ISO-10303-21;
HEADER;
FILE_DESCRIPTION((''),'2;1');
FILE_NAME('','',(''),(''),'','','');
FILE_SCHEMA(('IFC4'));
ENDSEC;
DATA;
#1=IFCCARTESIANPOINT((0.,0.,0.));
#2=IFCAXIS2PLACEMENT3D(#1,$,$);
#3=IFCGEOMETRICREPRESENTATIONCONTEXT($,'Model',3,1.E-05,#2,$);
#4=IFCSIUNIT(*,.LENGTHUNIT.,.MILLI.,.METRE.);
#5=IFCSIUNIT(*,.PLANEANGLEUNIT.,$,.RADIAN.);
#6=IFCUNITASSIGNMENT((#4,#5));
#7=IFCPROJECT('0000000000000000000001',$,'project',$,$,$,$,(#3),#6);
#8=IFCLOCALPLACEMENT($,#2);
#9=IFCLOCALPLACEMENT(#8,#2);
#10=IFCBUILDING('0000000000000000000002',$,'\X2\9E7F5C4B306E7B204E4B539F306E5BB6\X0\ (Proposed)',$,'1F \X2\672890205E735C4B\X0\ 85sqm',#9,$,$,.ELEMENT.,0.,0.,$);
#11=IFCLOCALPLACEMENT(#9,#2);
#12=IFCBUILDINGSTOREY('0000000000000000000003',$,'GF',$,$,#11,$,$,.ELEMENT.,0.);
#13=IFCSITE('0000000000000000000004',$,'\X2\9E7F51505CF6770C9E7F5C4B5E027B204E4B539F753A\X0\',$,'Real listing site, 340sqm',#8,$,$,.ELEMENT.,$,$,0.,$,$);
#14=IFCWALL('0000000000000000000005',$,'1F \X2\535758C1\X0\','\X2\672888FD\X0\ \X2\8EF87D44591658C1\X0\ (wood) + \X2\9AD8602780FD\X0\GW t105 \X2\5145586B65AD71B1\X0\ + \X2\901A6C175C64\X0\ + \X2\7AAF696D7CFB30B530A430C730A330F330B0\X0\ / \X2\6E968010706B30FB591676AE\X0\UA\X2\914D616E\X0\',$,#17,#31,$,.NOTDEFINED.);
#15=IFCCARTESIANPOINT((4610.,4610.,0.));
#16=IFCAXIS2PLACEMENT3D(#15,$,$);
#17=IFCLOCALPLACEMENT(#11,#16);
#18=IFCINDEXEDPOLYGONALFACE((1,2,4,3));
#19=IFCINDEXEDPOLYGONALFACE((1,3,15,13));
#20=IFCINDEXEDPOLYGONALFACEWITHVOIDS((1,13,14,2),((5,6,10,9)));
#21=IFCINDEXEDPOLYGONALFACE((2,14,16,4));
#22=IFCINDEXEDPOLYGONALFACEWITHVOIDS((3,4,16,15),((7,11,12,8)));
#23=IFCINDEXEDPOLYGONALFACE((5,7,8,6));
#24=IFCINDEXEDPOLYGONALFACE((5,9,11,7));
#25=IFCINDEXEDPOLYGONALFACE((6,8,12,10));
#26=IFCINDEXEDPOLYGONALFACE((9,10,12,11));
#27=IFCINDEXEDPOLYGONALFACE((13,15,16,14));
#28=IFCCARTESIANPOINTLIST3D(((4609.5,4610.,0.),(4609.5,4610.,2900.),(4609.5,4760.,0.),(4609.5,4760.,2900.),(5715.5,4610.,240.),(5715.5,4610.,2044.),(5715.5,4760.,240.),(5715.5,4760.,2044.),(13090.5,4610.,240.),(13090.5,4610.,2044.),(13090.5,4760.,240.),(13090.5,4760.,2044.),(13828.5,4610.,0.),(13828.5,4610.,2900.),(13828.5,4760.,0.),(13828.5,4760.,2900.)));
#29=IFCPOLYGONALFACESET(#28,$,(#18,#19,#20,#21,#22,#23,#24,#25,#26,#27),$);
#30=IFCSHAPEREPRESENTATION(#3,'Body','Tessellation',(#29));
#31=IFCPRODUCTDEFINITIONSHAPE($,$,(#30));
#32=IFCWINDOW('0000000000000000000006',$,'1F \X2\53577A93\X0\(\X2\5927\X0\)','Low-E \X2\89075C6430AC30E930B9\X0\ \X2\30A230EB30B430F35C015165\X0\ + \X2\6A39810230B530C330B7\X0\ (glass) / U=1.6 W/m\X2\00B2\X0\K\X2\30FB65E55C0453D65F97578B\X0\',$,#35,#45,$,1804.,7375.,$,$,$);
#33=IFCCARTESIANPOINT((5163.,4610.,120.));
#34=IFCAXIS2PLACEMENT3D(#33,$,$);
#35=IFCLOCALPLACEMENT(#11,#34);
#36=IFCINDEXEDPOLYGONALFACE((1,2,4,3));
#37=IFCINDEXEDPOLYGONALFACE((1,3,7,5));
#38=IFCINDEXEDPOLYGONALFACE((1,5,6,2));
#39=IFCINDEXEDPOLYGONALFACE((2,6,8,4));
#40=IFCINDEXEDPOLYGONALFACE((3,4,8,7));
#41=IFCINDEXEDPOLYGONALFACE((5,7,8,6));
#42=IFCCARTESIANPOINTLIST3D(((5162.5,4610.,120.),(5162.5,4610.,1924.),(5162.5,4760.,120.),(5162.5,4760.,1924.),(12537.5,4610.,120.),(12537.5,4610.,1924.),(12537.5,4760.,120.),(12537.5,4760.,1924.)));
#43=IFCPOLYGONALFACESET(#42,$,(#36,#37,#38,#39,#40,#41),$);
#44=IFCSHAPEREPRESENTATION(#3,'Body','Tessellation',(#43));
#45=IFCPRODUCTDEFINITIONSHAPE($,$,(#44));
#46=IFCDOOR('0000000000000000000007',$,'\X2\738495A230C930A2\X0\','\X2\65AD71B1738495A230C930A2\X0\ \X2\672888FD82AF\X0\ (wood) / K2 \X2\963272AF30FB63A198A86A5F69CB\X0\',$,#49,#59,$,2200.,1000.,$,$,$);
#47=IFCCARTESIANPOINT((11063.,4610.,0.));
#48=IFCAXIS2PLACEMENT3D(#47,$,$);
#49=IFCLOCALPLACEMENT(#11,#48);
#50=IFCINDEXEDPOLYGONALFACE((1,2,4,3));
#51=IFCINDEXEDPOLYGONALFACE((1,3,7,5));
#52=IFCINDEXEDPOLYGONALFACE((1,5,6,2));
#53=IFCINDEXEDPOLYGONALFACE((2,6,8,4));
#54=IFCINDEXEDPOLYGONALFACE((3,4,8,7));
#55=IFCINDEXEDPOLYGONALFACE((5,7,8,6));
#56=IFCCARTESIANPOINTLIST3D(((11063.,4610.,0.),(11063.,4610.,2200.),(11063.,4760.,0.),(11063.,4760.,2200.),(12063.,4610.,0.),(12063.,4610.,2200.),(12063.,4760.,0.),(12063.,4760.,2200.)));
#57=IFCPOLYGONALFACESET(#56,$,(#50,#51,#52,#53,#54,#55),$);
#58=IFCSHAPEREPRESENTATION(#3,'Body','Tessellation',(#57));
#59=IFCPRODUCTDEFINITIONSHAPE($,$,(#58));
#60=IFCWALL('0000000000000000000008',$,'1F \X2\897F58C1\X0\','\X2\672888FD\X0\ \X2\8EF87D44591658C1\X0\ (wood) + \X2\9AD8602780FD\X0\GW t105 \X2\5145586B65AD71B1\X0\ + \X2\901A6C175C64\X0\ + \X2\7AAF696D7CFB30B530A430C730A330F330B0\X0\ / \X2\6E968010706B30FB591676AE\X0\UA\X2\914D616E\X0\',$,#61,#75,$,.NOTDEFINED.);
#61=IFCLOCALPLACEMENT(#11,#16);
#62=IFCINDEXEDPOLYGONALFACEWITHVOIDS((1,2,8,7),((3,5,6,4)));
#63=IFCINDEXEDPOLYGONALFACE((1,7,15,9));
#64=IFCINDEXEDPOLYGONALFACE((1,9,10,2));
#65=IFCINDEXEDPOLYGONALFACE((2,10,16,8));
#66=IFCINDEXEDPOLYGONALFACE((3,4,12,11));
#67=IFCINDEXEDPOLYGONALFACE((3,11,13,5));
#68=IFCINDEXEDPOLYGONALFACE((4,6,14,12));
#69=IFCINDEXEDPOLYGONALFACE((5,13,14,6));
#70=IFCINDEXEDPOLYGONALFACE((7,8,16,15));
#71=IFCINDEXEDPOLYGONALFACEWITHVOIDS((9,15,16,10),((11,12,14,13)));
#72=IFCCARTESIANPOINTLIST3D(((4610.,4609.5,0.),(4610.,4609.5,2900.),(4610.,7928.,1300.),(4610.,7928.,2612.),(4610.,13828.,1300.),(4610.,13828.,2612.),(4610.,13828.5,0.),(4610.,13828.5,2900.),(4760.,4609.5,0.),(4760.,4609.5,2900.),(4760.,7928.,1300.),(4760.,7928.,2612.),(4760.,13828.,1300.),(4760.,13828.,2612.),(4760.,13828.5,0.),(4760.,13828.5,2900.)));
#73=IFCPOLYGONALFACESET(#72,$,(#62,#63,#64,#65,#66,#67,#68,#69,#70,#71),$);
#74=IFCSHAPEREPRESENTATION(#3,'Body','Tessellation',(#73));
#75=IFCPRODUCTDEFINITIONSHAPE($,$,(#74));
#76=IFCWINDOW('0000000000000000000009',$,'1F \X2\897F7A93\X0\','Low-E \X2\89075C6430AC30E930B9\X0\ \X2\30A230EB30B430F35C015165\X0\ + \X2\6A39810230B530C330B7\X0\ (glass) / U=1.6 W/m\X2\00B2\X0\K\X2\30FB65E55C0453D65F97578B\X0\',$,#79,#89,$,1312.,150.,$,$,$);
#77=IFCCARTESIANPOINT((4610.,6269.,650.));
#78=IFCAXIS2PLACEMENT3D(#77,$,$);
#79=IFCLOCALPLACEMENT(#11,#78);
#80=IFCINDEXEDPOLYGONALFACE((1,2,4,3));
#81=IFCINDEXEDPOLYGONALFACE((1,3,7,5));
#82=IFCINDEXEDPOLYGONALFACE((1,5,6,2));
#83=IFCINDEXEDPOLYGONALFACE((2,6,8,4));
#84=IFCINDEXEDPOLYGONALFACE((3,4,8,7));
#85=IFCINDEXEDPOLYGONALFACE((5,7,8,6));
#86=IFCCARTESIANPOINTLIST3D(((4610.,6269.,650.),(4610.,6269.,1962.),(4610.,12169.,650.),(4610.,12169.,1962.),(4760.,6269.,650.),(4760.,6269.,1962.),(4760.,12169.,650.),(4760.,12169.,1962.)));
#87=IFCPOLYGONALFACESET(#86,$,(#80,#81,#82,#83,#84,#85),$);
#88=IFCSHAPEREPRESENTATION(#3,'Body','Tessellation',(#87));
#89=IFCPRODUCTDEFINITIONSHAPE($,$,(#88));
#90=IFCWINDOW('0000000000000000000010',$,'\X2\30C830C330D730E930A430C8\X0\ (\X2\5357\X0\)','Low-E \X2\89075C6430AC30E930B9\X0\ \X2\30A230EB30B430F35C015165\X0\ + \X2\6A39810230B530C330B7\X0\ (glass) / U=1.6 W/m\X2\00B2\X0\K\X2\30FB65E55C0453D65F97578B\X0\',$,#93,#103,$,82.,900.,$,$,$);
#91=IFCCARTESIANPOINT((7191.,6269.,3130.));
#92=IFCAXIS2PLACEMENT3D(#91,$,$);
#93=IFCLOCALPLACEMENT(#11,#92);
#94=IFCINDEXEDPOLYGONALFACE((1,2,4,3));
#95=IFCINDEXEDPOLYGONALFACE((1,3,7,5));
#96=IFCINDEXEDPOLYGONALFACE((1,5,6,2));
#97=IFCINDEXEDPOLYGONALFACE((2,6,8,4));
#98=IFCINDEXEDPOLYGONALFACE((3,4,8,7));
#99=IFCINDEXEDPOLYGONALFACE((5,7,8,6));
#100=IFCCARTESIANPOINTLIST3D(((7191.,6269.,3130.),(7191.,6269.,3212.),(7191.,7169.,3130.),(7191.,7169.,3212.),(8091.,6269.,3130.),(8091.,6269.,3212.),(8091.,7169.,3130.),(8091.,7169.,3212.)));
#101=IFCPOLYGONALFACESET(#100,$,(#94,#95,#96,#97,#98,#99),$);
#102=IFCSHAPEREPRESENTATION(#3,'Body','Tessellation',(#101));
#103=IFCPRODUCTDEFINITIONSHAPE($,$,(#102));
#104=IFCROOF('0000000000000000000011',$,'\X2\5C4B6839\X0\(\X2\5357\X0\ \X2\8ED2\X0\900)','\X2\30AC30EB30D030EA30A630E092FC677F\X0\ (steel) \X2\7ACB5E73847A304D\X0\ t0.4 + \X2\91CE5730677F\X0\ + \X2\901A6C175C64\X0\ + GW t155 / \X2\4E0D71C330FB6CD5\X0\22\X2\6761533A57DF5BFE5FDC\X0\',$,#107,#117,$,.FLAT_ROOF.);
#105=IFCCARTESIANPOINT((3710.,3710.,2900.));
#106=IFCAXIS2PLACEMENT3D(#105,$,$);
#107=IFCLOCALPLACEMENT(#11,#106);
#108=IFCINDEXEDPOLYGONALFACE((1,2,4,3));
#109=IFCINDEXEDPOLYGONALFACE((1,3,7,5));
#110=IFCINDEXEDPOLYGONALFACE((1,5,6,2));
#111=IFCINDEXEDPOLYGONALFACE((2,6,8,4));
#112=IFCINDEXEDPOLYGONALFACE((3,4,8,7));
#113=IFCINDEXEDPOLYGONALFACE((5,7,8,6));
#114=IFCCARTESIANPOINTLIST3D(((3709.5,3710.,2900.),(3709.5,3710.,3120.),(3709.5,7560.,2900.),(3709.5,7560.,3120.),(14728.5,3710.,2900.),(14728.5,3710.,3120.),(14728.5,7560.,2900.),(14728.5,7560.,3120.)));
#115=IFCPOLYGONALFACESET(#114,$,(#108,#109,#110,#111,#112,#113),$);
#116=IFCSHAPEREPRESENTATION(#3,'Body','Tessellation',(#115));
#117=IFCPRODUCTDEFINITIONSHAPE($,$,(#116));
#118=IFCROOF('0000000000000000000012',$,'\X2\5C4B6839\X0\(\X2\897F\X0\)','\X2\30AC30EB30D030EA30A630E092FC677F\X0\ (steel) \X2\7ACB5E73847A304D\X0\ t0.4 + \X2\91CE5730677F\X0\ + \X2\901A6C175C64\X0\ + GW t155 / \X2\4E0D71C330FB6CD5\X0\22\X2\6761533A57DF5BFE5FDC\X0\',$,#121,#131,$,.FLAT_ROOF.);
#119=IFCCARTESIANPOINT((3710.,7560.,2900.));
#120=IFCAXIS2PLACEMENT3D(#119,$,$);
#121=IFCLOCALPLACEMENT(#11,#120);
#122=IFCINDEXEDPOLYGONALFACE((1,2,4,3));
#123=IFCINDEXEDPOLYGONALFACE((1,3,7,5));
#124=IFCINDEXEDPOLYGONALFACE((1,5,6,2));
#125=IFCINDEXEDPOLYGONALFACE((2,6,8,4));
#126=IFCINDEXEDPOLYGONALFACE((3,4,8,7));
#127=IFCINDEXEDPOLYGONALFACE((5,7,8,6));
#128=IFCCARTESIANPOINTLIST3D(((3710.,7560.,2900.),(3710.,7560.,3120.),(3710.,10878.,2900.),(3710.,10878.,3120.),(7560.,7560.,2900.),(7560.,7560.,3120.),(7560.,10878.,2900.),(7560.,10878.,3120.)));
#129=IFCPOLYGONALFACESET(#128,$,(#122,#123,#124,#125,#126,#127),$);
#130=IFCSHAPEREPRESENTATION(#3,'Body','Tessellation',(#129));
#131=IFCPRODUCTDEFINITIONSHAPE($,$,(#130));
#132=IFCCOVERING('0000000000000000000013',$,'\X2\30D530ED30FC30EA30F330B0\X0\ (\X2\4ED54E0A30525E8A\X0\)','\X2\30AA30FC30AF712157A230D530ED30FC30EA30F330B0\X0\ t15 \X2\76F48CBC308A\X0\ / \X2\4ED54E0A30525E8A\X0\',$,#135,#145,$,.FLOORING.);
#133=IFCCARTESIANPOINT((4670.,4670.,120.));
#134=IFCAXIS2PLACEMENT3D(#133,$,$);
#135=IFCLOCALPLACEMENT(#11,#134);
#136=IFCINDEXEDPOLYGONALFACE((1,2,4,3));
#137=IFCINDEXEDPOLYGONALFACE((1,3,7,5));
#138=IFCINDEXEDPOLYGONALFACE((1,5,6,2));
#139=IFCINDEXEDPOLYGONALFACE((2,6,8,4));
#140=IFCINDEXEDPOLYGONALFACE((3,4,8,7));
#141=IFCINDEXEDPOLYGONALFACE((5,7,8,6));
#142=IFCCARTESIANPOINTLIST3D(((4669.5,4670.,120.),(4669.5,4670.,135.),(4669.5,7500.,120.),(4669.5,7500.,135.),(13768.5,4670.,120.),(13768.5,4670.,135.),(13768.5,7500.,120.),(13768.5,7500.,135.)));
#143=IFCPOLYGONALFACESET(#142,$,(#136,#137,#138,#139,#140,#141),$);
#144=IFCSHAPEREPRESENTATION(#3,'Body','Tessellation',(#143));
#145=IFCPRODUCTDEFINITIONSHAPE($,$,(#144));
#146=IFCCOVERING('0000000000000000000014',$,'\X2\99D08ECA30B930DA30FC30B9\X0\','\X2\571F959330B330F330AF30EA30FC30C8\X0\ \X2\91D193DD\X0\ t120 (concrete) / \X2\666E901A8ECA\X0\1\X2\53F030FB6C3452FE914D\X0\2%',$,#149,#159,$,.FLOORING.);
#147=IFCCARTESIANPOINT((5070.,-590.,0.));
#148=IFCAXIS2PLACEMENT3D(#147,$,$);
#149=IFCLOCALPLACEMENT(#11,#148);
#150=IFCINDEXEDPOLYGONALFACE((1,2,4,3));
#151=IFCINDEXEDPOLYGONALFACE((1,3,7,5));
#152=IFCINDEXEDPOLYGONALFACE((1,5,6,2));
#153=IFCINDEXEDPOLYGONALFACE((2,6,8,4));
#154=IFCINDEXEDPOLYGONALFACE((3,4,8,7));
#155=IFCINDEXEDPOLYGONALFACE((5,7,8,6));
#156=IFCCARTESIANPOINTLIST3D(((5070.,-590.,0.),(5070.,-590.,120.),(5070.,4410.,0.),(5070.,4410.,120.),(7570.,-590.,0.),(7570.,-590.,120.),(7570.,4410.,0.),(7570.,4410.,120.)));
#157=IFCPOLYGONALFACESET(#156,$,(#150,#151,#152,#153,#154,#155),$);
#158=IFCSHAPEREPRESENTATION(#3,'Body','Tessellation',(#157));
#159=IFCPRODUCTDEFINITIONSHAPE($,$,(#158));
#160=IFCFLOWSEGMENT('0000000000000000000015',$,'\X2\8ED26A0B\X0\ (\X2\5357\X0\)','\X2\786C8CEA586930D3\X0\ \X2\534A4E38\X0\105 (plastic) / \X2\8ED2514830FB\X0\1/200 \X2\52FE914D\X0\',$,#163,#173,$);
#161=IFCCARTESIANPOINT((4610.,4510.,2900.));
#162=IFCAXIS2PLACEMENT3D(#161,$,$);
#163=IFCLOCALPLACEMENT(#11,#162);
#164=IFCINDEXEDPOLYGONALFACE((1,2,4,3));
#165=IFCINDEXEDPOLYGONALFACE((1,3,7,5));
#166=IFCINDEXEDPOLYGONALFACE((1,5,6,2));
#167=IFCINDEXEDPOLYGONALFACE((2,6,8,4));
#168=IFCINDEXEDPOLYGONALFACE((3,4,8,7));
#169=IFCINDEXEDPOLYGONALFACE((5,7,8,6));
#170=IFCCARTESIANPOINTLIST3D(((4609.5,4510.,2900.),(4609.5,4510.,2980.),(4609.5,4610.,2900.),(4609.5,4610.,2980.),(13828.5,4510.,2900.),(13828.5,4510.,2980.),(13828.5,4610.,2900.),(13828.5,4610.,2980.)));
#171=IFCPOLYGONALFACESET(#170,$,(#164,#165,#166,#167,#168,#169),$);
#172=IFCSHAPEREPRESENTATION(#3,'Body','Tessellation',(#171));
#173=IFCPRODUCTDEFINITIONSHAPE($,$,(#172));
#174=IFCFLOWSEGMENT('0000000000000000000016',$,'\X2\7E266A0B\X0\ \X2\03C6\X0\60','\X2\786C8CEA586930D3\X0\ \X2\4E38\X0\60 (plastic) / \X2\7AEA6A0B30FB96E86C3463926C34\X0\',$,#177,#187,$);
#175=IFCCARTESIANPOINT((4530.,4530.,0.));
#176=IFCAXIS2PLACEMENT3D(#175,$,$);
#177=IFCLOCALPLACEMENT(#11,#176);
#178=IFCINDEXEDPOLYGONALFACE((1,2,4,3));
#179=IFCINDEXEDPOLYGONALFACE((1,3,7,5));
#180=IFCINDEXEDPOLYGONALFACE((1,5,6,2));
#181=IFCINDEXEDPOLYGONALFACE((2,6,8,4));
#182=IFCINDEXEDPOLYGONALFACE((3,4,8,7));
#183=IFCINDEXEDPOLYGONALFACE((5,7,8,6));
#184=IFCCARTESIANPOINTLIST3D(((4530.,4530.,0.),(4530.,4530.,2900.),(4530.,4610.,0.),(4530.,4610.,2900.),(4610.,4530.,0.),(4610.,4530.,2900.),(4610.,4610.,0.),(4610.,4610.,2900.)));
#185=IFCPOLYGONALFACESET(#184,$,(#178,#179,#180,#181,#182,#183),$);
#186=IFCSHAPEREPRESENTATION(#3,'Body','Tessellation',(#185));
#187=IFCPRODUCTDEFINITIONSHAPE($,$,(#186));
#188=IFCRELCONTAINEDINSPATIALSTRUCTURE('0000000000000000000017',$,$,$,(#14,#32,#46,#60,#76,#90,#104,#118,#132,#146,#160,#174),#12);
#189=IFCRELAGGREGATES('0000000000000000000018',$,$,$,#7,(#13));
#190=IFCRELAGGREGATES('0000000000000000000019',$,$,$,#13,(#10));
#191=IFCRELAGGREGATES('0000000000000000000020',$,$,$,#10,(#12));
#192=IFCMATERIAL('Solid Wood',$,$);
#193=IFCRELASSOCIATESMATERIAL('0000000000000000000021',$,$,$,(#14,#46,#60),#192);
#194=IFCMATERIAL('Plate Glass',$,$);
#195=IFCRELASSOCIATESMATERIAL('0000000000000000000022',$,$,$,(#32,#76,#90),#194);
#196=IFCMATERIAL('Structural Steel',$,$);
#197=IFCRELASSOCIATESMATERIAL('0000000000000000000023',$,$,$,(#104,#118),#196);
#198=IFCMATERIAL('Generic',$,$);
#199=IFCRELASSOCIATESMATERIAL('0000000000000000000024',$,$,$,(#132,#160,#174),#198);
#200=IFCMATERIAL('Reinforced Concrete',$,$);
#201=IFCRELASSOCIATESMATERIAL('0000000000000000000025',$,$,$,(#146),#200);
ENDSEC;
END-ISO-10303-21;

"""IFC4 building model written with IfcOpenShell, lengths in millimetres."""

from ifc_helpers import new_model, si_unit, frame, frame_2d, origin, place, context, project, spatial, rectangle, extrude, material, element, fill, save


model = new_model("IFC4")

# Units and contexts
model_context = context("Model", 3, precision=1e-05, world=origin())
ifc_project = project(units=[si_unit("LENGTHUNIT", "METRE", prefix="MILLI"), si_unit("PLANEANGLEUNIT", "RADIAN")], contexts=[model_context])

# Site, building, storey
site_placement = place(None, origin())
site = spatial("IfcSite", under=ifc_project, at=site_placement, Name="鹿児島県鹿屋市笠之原町", ObjectType="Real listing site, 340sqm", CompositionType="ELEMENT", RefElevation=0.0)
building_placement = place(site_placement, origin())
building = spatial("IfcBuilding", under=site, at=building_placement, Name="鹿屋の笠之原の家 (Proposed)", ObjectType="1F 木造平屋 85sqm", CompositionType="ELEMENT", ElevationOfRefHeight=0.0, ElevationOfTerrain=0.0)
storey_placement = place(building_placement, origin())
storey = spatial("IfcBuildingStorey", under=building, at=storey_placement, Name="GF", CompositionType="ELEMENT", Elevation=0.0)

# Shared definitions
ifc_material_1 = material(Name="Solid Wood")

# Shared definitions
ifc_material_2 = material(Name="Reinforced Concrete")

# Wall, openings, window, door
wall_1_placement = place(storey_placement, frame((4610.0, 4610.0, 0.0)))
wall_1 = element("IfcWall", 1, at=wall_1_placement, inside=storey, material=ifc_material_1, Name="1F 南壁", Description="木製 軸組外壁 (wood) + 高性能GW t105 充填断熱 + 通気層 + 窯業系サイディング / 準耐火・外皮UA配慮", PredefinedType="NOTDEFINED", context=model_context, shape_type="SweptSolid", body=[
    extrude(rectangle(XDim=9219.0, YDim=150.0, at=frame_2d((4609.0, 75.0))), frame((4610.0, 4610.0, 0.0)), (0.0, 0.0, 1.0), 2900.0),
])
opening_1_placement = place(storey_placement, frame((5163.0, 4610.0, 120.0)))
opening_1 = element("IfcOpeningElement", 2, at=opening_1_placement, cuts=wall_1, PredefinedType="NOTDEFINED", context=model_context, shape_type="SweptSolid", body=[
    extrude(rectangle(XDim=7375.0, YDim=150.0, at=frame_2d((3687.0, 75.0))), frame((5163.0, 4610.0, 120.0)), (0.0, 0.0, 1.0), 1804.0),
])
opening_2_placement = place(storey_placement, frame((11063.0, 4610.0, 0.0)))
opening_2 = element("IfcOpeningElement", 3, at=opening_2_placement, cuts=wall_1, PredefinedType="NOTDEFINED", context=model_context, shape_type="SweptSolid", body=[
    extrude(rectangle(XDim=1000.0, YDim=150.0, at=frame_2d((500.0, 75.0))), frame((11063.0, 4610.0, 0.0)), (0.0, 0.0, 1.0), 2200.0),
])
ifc_material_3 = material(Name="Plate Glass")
window_1_placement = place(storey_placement, frame((5163.0, 4610.0, 120.0)))
window_1 = element("IfcWindow", 4, at=window_1_placement, inside=storey, material=ifc_material_3, Name="1F 南窓(大)", Description="Low-E 複層ガラス アルゴン封入 + 樹脂サッシ (glass) / U=1.6 W/m²K・日射取得型", OverallHeight=1804.0, OverallWidth=7375.0, context=model_context, shape_type="SweptSolid", body=[
    extrude(rectangle(XDim=7375.0, YDim=150.0, at=frame_2d((3687.0, 75.0))), frame((5163.0, 4610.0, 120.0)), (0.0, 0.0, 1.0), 1804.0),
])
fill(opening_1, window_1)
door_placement = place(storey_placement, frame((11063.0, 4610.0, 0.0)))
door = element("IfcDoor", 5, at=door_placement, inside=storey, material=ifc_material_1, Name="玄関ドア", Description="断熱玄関ドア 木製芯 (wood) / K2 防犯・採風機構", OverallHeight=2200.0, OverallWidth=1000.0, context=model_context, shape_type="SweptSolid", body=[
    extrude(rectangle(XDim=1000.0, YDim=150.0, at=frame_2d((500.0, 75.0))), frame((11063.0, 4610.0, 0.0)), (0.0, 0.0, 1.0), 2200.0),
])
fill(opening_2, door)

# Wall, opening, window
wall_2_placement = place(storey_placement, frame((4610.0, 4610.0, 0.0)))
wall_2 = element("IfcWall", 6, at=wall_2_placement, inside=storey, material=ifc_material_1, Name="1F 西壁", Description="木製 軸組外壁 (wood) + 高性能GW t105 充填断熱 + 通気層 + 窯業系サイディング / 準耐火・外皮UA配慮", PredefinedType="NOTDEFINED", context=model_context, shape_type="SweptSolid", body=[
    extrude(rectangle(XDim=150.0, YDim=9219.0, at=frame_2d((75.0, 4609.0))), frame((4610.0, 4610.0, 0.0)), (0.0, 0.0, 1.0), 2900.0),
])
opening_3_placement = place(storey_placement, frame((4610.0, 6269.0, 650.0)))
opening_3 = element("IfcOpeningElement", 7, at=opening_3_placement, cuts=wall_2, PredefinedType="NOTDEFINED", context=model_context, shape_type="SweptSolid", body=[
    extrude(rectangle(XDim=150.0, YDim=5900.0, at=frame_2d((75.0, 2950.0))), frame((4610.0, 6269.0, 650.0)), (0.0, 0.0, 1.0), 1312.0),
])
window_2_placement = place(storey_placement, frame((4610.0, 6269.0, 650.0)))
window_2 = element("IfcWindow", 8, at=window_2_placement, inside=storey, material=ifc_material_3, Name="1F 西窓", Description="Low-E 複層ガラス アルゴン封入 + 樹脂サッシ (glass) / U=1.6 W/m²K・日射取得型", OverallHeight=1312.0, OverallWidth=150.0, context=model_context, shape_type="SweptSolid", body=[
    extrude(rectangle(XDim=150.0, YDim=5900.0, at=frame_2d((75.0, 2950.0))), frame((4610.0, 6269.0, 650.0)), (0.0, 0.0, 1.0), 1312.0),
])
fill(opening_3, window_2)

# Window
window_3_placement = place(storey_placement, frame((7191.0, 6269.0, 3130.0)))
element("IfcWindow", 9, at=window_3_placement, inside=storey, material=ifc_material_3, Name="トップライト (南)", Description="Low-E 複層ガラス アルゴン封入 + 樹脂サッシ (glass) / U=1.6 W/m²K・日射取得型", OverallHeight=82.0, OverallWidth=900.0, context=model_context, shape_type="SweptSolid", body=[
    extrude(rectangle(XDim=900.0, YDim=900.0, at=frame_2d((450.0, 450.0))), frame((7191.0, 6269.0, 3130.0)), (0.0, 0.0, 1.0), 82.0),
])

# Roofs
ifc_material_4 = material(Name="Structural Steel")
roof_1_placement = place(storey_placement, frame((3710.0, 3710.0, 2900.0)))
element("IfcRoof", 10, at=roof_1_placement, inside=storey, material=ifc_material_4, Name="屋根(南 軒900)", Description="ガルバリウム鋼板 (steel) 立平葺き t0.4 + 野地板 + 通気層 + GW t155 / 不燃・法22条区域対応", PredefinedType="FLAT_ROOF", context=model_context, shape_type="SweptSolid", body=[
    extrude(rectangle(XDim=11019.0, YDim=3850.0, at=frame_2d((5509.0, 1925.0))), frame((3710.0, 3710.0, 2900.0)), (0.0, 0.0, 1.0), 220.0),
])
roof_2_placement = place(storey_placement, frame((3710.0, 7560.0, 2900.0)))
element("IfcRoof", 11, at=roof_2_placement, inside=storey, material=ifc_material_4, Name="屋根(西)", Description="ガルバリウム鋼板 (steel) 立平葺き t0.4 + 野地板 + 通気層 + GW t155 / 不燃・法22条区域対応", PredefinedType="FLAT_ROOF", context=model_context, shape_type="SweptSolid", body=[
    extrude(rectangle(XDim=3850.0, YDim=3318.0, at=frame_2d((1925.0, 1659.0))), frame((3710.0, 7560.0, 2900.0)), (0.0, 0.0, 1.0), 220.0),
])

# Coverings
ifc_material_5 = material(Name="Generic")
covering_1_placement = place(storey_placement, frame((4670.0, 4670.0, 120.0)))
element("IfcCovering", 12, at=covering_1_placement, inside=storey, material=ifc_material_5, Name="フローリング (仕上げ床)", Description="オーク無垢フローリング t15 直貼り / 仕上げ床", PredefinedType="FLOORING", context=model_context, shape_type="SweptSolid", body=[
    extrude(rectangle(XDim=9099.0, YDim=2830.0, at=frame_2d((4549.0, 1415.0))), frame((4670.0, 4670.0, 120.0)), (0.0, 0.0, 1.0), 15.0),
])
covering_2_placement = place(storey_placement, frame((5070.0, -590.0, 0.0)))
element("IfcCovering", 13, at=covering_2_placement, inside=storey, material=ifc_material_2, Name="駐車スペース", Description="土間コンクリート 金鏝 t120 (concrete) / 普通車1台・水勾配2%", PredefinedType="FLOORING", context=model_context, shape_type="SweptSolid", body=[
    extrude(rectangle(XDim=2500.0, YDim=5000.0, at=frame_2d((1250.0, 2500.0))), frame((5070.0, -590.0, 0.0)), (0.0, 0.0, 1.0), 120.0),
])

# Flow segments
flow_segment_1_placement = place(storey_placement, frame((4610.0, 4510.0, 2900.0)))
element("IfcFlowSegment", 14, at=flow_segment_1_placement, inside=storey, material=ifc_material_5, Name="軒樋 (南)", Description="硬質塩ビ 半丸105 (plastic) / 軒先・1/200 勾配", context=model_context, shape_type="SweptSolid", body=[
    extrude(rectangle(XDim=9219.0, YDim=100.0, at=frame_2d((4609.0, 50.0))), frame((4610.0, 4510.0, 2900.0)), (0.0, 0.0, 1.0), 80.0),
])
flow_segment_2_placement = place(storey_placement, frame((4530.0, 4530.0, 0.0)))
element("IfcFlowSegment", 15, at=flow_segment_2_placement, inside=storey, material=ifc_material_5, Name="縦樋 φ60", Description="硬質塩ビ 丸60 (plastic) / 竪樋・雨水排水", context=model_context, shape_type="SweptSolid", body=[
    extrude(rectangle(XDim=80.0, YDim=80.0, at=frame_2d((40.0, 40.0))), frame((4530.0, 4530.0, 0.0)), (0.0, 0.0, 1.0), 2900.0),
])

save(model, "model.ifc")
